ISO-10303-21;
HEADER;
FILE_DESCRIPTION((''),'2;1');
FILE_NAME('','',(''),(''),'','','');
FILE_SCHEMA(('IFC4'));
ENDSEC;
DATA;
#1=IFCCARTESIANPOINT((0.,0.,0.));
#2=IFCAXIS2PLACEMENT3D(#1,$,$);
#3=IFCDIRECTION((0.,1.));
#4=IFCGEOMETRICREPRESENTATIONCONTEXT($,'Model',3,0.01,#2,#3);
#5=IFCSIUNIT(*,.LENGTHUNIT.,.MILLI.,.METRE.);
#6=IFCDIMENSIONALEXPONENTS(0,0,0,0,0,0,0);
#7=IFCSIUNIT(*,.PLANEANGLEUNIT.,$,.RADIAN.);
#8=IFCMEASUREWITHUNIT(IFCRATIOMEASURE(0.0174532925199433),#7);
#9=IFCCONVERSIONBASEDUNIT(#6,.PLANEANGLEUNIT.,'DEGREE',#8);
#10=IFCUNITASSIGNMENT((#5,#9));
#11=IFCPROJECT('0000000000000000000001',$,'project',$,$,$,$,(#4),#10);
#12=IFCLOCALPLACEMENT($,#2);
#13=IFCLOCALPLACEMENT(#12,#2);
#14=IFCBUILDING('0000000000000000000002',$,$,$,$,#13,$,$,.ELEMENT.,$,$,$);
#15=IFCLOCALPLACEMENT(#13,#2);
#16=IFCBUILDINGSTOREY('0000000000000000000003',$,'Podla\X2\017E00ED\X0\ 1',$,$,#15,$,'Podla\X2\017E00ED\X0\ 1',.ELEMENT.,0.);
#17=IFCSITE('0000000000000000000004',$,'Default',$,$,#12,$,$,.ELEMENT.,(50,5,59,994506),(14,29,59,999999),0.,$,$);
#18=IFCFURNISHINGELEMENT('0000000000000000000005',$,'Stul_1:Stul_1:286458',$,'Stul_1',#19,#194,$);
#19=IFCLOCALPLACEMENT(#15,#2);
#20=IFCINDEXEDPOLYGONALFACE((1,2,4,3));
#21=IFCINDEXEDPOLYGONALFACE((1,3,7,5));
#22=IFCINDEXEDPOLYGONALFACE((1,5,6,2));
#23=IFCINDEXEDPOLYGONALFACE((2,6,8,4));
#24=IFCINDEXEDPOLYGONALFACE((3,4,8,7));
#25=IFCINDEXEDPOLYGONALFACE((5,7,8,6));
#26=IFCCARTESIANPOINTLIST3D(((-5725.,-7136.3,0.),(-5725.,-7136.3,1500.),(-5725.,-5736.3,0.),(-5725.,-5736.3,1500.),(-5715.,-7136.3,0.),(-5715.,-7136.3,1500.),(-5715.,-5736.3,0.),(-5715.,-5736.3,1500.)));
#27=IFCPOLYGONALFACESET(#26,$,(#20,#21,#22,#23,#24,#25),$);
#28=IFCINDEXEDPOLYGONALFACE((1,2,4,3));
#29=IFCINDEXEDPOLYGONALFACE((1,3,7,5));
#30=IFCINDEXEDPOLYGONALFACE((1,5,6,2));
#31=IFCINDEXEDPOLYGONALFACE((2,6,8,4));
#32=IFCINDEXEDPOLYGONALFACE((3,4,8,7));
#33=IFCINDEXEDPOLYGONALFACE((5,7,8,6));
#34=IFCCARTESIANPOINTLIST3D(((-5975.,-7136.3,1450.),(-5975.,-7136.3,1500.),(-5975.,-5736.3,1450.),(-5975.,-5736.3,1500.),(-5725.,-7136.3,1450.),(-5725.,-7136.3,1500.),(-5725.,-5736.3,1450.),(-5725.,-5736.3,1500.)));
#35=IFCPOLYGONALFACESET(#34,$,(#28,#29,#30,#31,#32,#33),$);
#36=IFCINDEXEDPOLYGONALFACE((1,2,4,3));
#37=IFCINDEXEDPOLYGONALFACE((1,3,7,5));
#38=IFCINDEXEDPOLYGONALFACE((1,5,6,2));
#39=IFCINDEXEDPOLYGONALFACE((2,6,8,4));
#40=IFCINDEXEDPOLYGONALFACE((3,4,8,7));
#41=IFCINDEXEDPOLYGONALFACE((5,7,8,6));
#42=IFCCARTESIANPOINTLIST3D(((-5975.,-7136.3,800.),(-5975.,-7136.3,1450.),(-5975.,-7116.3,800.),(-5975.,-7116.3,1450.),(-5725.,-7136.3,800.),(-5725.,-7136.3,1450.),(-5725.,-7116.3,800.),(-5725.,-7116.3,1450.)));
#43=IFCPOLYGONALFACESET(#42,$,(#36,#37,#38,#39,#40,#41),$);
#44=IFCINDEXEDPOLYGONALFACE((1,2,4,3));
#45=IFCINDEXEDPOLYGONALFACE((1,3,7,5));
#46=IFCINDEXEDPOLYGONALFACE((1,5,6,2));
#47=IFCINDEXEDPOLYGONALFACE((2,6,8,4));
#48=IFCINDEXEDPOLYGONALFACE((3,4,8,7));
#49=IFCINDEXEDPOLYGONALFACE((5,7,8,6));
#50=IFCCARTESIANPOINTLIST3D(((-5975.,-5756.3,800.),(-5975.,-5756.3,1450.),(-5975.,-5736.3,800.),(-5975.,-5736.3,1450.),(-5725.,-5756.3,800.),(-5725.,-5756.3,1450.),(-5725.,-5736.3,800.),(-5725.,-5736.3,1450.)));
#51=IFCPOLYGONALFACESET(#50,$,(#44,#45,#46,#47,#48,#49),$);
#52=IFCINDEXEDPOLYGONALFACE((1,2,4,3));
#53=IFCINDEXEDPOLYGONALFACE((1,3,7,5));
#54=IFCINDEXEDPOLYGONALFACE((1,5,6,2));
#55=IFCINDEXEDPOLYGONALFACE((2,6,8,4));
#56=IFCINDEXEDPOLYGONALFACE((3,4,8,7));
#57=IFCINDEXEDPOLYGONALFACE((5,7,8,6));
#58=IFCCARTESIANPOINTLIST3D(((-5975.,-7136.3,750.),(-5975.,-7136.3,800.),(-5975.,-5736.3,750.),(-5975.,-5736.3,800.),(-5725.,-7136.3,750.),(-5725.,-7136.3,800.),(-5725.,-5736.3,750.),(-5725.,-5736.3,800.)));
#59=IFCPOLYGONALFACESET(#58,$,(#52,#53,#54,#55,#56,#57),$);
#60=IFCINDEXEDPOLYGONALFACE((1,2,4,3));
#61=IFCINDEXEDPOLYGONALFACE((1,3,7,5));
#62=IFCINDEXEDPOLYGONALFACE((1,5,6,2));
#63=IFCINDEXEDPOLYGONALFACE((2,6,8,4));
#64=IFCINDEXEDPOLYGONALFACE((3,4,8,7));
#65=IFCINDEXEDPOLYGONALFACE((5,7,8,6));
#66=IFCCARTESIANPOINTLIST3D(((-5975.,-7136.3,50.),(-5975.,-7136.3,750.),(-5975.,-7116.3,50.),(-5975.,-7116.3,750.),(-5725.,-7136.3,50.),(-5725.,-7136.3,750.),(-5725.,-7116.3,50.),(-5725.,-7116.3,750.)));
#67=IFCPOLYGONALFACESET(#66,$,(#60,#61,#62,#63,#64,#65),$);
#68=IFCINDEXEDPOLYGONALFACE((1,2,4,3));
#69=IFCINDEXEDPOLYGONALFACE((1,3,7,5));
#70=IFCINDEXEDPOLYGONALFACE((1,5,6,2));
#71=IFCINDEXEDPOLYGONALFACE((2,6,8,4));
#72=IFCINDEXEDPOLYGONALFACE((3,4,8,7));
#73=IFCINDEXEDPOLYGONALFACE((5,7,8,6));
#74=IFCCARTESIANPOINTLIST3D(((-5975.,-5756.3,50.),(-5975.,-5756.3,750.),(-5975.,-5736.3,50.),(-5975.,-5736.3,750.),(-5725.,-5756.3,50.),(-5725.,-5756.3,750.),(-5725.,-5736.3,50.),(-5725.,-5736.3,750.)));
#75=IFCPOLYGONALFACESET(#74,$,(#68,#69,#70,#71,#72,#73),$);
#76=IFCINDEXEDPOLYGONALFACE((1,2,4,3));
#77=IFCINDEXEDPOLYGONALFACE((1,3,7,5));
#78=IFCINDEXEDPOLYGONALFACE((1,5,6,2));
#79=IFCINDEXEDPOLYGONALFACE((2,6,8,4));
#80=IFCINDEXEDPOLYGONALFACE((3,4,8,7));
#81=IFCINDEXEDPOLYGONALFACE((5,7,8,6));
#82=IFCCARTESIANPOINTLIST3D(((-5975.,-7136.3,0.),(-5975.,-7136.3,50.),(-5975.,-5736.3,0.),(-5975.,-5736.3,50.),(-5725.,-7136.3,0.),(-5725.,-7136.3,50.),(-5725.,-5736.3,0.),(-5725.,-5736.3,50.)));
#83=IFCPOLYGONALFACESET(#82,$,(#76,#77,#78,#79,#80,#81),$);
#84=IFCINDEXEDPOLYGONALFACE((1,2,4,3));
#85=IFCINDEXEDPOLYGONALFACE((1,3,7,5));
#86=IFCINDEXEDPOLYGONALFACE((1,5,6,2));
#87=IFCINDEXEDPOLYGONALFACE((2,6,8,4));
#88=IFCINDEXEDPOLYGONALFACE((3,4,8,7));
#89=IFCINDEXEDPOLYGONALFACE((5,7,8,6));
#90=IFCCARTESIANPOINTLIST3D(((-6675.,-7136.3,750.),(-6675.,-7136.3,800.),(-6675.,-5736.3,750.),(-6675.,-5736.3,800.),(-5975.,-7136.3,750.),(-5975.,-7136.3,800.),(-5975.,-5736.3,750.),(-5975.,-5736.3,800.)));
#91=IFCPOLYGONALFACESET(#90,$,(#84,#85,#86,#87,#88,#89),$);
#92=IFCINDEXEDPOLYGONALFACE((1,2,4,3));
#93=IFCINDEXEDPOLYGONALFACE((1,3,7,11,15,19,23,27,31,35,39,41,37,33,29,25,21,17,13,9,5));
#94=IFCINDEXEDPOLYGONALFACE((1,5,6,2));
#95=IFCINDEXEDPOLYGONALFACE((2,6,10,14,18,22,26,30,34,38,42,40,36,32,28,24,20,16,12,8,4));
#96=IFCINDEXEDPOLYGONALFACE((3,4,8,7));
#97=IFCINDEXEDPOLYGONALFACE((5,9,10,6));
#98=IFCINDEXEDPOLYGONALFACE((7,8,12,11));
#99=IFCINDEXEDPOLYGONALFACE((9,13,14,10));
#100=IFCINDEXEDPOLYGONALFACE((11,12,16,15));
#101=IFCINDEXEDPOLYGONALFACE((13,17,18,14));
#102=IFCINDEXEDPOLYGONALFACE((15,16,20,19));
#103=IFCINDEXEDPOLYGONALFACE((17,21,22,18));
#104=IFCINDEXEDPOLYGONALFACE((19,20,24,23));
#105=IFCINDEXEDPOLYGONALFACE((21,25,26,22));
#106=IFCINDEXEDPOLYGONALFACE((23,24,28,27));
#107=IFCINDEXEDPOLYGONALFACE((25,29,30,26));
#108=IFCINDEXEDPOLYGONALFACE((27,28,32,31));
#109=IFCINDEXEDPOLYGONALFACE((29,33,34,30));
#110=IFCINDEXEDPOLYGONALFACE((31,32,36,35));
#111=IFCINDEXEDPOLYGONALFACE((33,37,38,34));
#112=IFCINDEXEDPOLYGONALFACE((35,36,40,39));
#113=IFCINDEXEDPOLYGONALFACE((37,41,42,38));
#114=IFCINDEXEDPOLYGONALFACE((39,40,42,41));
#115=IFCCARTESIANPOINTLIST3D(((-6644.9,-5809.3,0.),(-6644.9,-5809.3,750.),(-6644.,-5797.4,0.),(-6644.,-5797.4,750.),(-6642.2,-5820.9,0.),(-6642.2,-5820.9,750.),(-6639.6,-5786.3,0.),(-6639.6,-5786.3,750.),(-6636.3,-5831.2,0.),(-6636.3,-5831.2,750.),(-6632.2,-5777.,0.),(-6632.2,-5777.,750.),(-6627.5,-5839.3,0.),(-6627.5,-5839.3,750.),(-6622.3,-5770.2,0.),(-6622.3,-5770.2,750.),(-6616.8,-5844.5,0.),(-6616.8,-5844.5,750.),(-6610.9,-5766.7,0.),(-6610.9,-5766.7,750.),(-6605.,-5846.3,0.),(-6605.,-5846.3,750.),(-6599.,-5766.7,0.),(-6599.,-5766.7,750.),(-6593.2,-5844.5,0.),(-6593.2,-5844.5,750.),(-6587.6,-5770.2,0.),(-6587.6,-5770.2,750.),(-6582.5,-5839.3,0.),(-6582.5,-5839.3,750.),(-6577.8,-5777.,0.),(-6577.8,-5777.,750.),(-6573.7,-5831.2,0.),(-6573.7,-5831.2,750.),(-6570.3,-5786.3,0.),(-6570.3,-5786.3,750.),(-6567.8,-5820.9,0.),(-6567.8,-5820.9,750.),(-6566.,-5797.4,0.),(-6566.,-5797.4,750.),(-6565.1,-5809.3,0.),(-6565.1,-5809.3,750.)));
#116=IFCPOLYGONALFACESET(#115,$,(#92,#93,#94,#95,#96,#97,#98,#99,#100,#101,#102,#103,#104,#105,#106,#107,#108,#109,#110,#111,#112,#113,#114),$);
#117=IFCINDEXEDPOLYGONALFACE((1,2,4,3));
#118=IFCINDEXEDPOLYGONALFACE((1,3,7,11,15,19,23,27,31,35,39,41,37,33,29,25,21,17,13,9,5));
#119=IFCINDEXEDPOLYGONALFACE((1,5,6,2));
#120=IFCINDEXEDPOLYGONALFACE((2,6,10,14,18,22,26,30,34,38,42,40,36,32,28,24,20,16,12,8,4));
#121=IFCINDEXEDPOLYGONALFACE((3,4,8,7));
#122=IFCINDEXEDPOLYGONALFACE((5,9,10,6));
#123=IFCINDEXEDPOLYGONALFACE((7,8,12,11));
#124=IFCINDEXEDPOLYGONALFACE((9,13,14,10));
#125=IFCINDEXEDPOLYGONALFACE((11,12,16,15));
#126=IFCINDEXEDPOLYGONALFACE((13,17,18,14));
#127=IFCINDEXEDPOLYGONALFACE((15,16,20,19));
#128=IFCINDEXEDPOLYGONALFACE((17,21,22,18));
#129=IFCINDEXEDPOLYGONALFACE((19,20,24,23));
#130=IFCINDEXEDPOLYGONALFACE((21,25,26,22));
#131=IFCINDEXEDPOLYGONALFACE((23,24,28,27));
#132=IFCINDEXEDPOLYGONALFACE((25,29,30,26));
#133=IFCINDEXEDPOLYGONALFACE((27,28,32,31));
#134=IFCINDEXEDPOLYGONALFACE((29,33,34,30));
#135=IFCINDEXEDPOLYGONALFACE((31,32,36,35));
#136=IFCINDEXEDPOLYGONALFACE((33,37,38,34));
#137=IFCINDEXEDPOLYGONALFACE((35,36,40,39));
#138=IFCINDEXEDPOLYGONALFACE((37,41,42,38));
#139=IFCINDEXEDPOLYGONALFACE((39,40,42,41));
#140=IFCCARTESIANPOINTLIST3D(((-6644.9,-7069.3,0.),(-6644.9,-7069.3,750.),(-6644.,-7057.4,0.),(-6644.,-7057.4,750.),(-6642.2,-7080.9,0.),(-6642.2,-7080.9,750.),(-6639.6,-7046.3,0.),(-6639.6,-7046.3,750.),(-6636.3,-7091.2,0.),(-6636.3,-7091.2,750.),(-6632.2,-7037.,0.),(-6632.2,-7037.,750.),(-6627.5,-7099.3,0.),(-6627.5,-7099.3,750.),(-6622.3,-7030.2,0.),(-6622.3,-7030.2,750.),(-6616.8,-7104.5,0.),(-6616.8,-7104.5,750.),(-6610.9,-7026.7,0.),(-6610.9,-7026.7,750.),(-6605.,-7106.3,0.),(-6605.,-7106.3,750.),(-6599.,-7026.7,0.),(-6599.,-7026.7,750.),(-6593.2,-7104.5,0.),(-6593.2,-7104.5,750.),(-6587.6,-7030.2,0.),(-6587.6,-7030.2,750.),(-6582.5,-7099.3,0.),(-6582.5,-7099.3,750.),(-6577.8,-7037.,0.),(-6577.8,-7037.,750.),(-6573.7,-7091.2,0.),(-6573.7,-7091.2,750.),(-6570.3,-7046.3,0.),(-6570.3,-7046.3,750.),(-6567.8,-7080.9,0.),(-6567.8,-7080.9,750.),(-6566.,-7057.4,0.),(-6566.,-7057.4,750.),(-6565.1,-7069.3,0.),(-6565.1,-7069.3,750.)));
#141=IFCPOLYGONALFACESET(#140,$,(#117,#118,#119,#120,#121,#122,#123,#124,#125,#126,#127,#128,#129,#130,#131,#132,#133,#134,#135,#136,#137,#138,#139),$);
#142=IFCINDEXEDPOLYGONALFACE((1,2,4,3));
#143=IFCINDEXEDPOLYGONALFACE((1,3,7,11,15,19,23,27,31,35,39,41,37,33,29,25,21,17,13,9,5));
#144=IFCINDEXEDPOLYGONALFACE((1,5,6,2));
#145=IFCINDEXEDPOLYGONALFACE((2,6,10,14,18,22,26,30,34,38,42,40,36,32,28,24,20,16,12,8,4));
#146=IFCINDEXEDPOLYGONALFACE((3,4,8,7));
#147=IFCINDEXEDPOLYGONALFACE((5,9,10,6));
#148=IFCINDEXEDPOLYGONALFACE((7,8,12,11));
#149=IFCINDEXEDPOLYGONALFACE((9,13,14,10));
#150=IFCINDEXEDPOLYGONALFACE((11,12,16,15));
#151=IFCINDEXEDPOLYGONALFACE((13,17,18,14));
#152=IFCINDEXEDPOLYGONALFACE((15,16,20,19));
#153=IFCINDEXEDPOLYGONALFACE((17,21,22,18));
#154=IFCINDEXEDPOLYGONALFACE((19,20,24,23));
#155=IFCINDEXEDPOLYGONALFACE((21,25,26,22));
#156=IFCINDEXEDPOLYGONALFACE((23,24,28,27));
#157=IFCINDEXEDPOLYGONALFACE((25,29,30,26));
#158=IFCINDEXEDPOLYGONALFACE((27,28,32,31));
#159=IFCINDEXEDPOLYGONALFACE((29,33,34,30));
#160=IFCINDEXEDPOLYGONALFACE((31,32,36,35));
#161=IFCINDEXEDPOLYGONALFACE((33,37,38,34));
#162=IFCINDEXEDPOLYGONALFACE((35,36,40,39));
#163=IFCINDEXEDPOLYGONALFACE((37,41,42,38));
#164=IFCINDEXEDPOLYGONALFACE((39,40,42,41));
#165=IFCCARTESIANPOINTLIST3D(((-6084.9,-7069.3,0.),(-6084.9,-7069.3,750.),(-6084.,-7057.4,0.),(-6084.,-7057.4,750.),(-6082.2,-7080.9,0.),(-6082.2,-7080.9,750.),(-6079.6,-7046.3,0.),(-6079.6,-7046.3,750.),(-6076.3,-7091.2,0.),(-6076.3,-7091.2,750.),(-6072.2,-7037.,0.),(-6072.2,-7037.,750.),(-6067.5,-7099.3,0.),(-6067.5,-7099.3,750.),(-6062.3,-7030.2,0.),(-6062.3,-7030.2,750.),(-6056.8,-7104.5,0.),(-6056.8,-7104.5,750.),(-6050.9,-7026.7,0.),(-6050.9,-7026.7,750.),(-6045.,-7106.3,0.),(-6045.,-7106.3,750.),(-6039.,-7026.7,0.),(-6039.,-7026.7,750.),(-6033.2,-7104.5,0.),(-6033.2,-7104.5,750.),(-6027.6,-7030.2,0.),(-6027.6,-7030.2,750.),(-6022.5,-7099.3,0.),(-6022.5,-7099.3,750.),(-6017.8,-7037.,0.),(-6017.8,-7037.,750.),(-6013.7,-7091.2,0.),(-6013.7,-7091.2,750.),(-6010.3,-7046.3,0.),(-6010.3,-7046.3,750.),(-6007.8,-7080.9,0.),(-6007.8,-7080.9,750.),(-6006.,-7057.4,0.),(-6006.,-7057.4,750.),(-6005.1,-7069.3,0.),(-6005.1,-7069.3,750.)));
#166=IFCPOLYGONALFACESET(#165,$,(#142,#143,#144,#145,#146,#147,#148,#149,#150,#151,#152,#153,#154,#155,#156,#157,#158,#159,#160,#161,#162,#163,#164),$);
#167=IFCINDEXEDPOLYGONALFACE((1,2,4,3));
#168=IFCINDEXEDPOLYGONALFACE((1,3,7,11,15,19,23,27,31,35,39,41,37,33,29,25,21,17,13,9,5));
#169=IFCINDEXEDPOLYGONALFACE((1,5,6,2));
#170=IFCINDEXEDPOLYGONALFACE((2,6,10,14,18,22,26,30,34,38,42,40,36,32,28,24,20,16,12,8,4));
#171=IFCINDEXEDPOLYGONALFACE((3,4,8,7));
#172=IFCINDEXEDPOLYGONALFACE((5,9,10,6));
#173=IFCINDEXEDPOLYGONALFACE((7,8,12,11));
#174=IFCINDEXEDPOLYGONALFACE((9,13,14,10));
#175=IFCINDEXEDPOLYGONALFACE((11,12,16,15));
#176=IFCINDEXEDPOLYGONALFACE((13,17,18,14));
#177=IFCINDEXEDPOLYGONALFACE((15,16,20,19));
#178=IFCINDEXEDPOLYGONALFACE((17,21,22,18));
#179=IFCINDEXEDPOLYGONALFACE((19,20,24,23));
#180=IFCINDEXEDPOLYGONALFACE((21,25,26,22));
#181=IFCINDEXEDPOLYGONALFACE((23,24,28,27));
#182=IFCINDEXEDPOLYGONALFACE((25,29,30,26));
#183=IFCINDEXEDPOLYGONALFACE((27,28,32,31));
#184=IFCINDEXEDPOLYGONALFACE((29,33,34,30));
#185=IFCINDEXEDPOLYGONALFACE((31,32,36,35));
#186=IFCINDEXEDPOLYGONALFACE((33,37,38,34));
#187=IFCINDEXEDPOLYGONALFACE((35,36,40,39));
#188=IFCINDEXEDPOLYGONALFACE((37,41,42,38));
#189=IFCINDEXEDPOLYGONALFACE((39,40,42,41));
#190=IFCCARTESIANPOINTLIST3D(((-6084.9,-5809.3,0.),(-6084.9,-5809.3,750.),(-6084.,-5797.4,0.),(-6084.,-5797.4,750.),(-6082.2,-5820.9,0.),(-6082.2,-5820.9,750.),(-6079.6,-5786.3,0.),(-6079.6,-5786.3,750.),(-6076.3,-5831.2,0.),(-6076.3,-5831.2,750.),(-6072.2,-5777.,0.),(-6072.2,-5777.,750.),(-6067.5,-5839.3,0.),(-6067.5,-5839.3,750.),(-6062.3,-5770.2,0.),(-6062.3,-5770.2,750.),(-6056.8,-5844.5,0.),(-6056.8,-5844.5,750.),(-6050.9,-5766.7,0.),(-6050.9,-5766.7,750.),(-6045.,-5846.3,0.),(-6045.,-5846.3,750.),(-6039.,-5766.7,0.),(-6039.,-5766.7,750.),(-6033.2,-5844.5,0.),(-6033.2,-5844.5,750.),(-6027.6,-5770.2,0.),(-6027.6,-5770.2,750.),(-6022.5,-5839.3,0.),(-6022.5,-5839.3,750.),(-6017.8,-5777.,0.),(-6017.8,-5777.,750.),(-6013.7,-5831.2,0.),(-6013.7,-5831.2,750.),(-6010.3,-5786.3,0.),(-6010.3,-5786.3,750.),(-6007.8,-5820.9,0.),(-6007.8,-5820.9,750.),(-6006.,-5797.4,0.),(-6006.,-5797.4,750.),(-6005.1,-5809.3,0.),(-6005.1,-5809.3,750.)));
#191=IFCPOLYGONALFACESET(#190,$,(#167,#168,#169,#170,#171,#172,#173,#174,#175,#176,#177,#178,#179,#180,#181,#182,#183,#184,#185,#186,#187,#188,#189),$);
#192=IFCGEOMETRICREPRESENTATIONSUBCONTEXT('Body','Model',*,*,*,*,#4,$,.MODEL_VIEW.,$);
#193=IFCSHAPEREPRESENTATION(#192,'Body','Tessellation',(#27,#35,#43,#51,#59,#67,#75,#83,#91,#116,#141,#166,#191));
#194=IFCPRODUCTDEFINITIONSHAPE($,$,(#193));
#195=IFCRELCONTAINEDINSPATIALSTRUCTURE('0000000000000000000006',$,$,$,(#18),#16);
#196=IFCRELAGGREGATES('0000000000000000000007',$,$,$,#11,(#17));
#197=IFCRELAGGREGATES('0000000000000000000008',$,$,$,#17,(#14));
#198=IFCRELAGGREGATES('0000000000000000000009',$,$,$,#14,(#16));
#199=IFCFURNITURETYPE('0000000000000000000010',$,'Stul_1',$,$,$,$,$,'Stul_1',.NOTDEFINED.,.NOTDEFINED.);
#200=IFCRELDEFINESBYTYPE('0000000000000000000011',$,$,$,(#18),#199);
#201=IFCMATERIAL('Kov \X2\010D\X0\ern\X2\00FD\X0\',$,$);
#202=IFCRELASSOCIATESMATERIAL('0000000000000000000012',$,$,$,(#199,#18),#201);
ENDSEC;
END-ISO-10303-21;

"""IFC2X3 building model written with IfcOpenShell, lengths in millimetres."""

from ifc_helpers import new_model, entity, si_unit, converted_unit, direction, frame, frame_2d, origin, origin_2d_with_axis, place, context, subcontext, project, spatial, rectangle, circle, extrude, source, transform, mapped, material, type_object, type_shapes, element, save


model = new_model("IFC2X3")

# Units and contexts
model_context = context("Model", 3, precision=0.01, world=origin(), true_north=direction((0.0, 1.0)))
body_context = subcontext(model_context, "Body", "Model", "MODEL_VIEW")
ifc_project = project(units=[si_unit("LENGTHUNIT", "METRE", prefix="MILLI"), converted_unit("PLANEANGLEUNIT", "DEGREE", entity("IfcRatioMeasure", 0.0174532925199433), si_unit("PLANEANGLEUNIT", "RADIAN"), dimensions=[0, 0, 0, 0, 0, 0, 0])], contexts=[model_context])

# Site, building, storey
site_placement = place(None, origin())
site = spatial("IfcSite", under=ifc_project, at=site_placement, Name="Default", CompositionType="ELEMENT", RefLatitude=(50, 5, 59, 994506), RefLongitude=(14, 29, 59, 999999), RefElevation=0.0)
building_placement = place(site_placement, origin())
building = spatial("IfcBuilding", under=site, at=building_placement, CompositionType="ELEMENT")
storey_placement = place(building_placement, origin())
storey = spatial("IfcBuildingStorey", under=building, at=storey_placement, Name="Podlaží 1", LongName="Podlaží 1", CompositionType="ELEMENT", Elevation=0.0)

# Furnishing element
ifc_material_1 = material(Name="Kov černý")
furniture_type = type_object("IfcFurnitureType", Name="Stul_1", ElementType="Stul_1", material=ifc_material_1)
shared_shape_1 = source(origin(), body_context, "Body", "SweptSolid", [
    extrude(rectangle(XDim=1400.0, YDim=10.0, at=origin_2d_with_axis()), frame((0.0, 605.0, 0.0), z_axis=(0.0, 0.0, 1.0), x_axis=(-1.0, 0.0, 0.0)), (0.0, 0.0, 1.0), 1500.0),
    extrude(rectangle(XDim=1400.0, YDim=250.0, at=frame_2d((0.0, 0.0), x_axis=(1.0, 0.0))), frame((0.0, 475.0, 1450.0), z_axis=(0.0, 0.0, 1.0), x_axis=(-1.0, 0.0, 0.0)), (0.0, 0.0, 1.0), 50.0),
    extrude(rectangle(XDim=20.0, YDim=250.0, at=origin_2d_with_axis()), frame((690.0, 475.0, 800.0), z_axis=(0.0, 0.0, 1.0), x_axis=(-1.0, 0.0, 0.0)), (0.0, 0.0, 1.0), 650.0),
    extrude(rectangle(XDim=20.0, YDim=250.0, at=frame_2d((0.0, 0.0), x_axis=(1.0, 0.0))), frame((-690.0, 475.0, 800.0), z_axis=(0.0, 0.0, 1.0), x_axis=(-1.0, 0.0, 0.0)), (0.0, 0.0, 1.0), 650.0),
    extrude(rectangle(XDim=1400.0, YDim=250.0, at=origin_2d_with_axis()), frame((0.0, 475.0, 750.0), z_axis=(0.0, 0.0, 1.0), x_axis=(-1.0, 0.0, 0.0)), (0.0, 0.0, 1.0), 50.0),
    extrude(rectangle(XDim=20.0, YDim=250.0, at=origin_2d_with_axis()), frame((690.0, 475.0, 50.0), z_axis=(0.0, 0.0, 1.0), x_axis=(-1.0, 0.0, 0.0)), (0.0, 0.0, 1.0), 700.0),
    extrude(rectangle(XDim=20.0, YDim=250.0, at=frame_2d((0.0, 0.0), x_axis=(1.0, 0.0))), frame((-690.0, 475.0, 50.0), z_axis=(0.0, 0.0, 1.0), x_axis=(-1.0, 0.0, 0.0)), (0.0, 0.0, 1.0), 700.0),
    extrude(rectangle(XDim=1400.0, YDim=250.0, at=origin_2d_with_axis()), frame((0.0, 475.0, 0.0), z_axis=(0.0, 0.0, 1.0), x_axis=(-1.0, 0.0, 0.0)), (0.0, 0.0, 1.0), 50.0),
    extrude(rectangle(XDim=1400.0, YDim=700.0, at=origin_2d_with_axis()), frame((0.0, 0.0, 750.0), z_axis=(0.0, 0.0, 1.0), x_axis=(-1.0, 0.0, 0.0)), (0.0, 0.0, 1.0), 50.0),
    extrude(circle(Radius=40.0, at=frame_2d((0.0, 0.0), x_axis=(1.0, 0.0))), frame((-630.0, -280.0, 0.0)), (0.0, 0.0, 1.0), 750.0),
    extrude(circle(Radius=40.0, at=frame_2d((0.0, 0.0), x_axis=(1.0, 0.0))), frame((630.0, -280.0, 0.0)), (0.0, 0.0, 1.0), 750.0),
    extrude(circle(Radius=40.0, at=frame_2d((0.0, 0.0), x_axis=(1.0, 0.0))), frame((630.0, 280.0, 0.0)), (0.0, 0.0, 1.0), 750.0),
    extrude(circle(Radius=40.0, at=frame_2d((0.0, 0.0), x_axis=(1.0, 0.0))), frame((-630.0, 280.0, 0.0)), (0.0, 0.0, 1.0), 750.0),
])
type_shapes(furniture_type, [shared_shape_1])
for number, where, z_axis, x_axis, name in (
    (1, (-6325.0, -6436.3, 0.0), (0.0, 0.0, 1.0), (0.0, -1.0, 0.0), "Stul_1:Stul_1:286458"),
):
    element("IfcFurnishingElement", number, at=place(storey_placement, frame(where, z_axis=z_axis, x_axis=x_axis)), inside=storey, type_object=furniture_type, material=ifc_material_1, Name=name, ObjectType="Stul_1", context=body_context, shape_type="MappedRepresentation", body=[
        mapped(shared_shape_1, transform((0.0, 0.0, 0.0), scale=1.0)),
    ])

save(model, "model.ifc")
